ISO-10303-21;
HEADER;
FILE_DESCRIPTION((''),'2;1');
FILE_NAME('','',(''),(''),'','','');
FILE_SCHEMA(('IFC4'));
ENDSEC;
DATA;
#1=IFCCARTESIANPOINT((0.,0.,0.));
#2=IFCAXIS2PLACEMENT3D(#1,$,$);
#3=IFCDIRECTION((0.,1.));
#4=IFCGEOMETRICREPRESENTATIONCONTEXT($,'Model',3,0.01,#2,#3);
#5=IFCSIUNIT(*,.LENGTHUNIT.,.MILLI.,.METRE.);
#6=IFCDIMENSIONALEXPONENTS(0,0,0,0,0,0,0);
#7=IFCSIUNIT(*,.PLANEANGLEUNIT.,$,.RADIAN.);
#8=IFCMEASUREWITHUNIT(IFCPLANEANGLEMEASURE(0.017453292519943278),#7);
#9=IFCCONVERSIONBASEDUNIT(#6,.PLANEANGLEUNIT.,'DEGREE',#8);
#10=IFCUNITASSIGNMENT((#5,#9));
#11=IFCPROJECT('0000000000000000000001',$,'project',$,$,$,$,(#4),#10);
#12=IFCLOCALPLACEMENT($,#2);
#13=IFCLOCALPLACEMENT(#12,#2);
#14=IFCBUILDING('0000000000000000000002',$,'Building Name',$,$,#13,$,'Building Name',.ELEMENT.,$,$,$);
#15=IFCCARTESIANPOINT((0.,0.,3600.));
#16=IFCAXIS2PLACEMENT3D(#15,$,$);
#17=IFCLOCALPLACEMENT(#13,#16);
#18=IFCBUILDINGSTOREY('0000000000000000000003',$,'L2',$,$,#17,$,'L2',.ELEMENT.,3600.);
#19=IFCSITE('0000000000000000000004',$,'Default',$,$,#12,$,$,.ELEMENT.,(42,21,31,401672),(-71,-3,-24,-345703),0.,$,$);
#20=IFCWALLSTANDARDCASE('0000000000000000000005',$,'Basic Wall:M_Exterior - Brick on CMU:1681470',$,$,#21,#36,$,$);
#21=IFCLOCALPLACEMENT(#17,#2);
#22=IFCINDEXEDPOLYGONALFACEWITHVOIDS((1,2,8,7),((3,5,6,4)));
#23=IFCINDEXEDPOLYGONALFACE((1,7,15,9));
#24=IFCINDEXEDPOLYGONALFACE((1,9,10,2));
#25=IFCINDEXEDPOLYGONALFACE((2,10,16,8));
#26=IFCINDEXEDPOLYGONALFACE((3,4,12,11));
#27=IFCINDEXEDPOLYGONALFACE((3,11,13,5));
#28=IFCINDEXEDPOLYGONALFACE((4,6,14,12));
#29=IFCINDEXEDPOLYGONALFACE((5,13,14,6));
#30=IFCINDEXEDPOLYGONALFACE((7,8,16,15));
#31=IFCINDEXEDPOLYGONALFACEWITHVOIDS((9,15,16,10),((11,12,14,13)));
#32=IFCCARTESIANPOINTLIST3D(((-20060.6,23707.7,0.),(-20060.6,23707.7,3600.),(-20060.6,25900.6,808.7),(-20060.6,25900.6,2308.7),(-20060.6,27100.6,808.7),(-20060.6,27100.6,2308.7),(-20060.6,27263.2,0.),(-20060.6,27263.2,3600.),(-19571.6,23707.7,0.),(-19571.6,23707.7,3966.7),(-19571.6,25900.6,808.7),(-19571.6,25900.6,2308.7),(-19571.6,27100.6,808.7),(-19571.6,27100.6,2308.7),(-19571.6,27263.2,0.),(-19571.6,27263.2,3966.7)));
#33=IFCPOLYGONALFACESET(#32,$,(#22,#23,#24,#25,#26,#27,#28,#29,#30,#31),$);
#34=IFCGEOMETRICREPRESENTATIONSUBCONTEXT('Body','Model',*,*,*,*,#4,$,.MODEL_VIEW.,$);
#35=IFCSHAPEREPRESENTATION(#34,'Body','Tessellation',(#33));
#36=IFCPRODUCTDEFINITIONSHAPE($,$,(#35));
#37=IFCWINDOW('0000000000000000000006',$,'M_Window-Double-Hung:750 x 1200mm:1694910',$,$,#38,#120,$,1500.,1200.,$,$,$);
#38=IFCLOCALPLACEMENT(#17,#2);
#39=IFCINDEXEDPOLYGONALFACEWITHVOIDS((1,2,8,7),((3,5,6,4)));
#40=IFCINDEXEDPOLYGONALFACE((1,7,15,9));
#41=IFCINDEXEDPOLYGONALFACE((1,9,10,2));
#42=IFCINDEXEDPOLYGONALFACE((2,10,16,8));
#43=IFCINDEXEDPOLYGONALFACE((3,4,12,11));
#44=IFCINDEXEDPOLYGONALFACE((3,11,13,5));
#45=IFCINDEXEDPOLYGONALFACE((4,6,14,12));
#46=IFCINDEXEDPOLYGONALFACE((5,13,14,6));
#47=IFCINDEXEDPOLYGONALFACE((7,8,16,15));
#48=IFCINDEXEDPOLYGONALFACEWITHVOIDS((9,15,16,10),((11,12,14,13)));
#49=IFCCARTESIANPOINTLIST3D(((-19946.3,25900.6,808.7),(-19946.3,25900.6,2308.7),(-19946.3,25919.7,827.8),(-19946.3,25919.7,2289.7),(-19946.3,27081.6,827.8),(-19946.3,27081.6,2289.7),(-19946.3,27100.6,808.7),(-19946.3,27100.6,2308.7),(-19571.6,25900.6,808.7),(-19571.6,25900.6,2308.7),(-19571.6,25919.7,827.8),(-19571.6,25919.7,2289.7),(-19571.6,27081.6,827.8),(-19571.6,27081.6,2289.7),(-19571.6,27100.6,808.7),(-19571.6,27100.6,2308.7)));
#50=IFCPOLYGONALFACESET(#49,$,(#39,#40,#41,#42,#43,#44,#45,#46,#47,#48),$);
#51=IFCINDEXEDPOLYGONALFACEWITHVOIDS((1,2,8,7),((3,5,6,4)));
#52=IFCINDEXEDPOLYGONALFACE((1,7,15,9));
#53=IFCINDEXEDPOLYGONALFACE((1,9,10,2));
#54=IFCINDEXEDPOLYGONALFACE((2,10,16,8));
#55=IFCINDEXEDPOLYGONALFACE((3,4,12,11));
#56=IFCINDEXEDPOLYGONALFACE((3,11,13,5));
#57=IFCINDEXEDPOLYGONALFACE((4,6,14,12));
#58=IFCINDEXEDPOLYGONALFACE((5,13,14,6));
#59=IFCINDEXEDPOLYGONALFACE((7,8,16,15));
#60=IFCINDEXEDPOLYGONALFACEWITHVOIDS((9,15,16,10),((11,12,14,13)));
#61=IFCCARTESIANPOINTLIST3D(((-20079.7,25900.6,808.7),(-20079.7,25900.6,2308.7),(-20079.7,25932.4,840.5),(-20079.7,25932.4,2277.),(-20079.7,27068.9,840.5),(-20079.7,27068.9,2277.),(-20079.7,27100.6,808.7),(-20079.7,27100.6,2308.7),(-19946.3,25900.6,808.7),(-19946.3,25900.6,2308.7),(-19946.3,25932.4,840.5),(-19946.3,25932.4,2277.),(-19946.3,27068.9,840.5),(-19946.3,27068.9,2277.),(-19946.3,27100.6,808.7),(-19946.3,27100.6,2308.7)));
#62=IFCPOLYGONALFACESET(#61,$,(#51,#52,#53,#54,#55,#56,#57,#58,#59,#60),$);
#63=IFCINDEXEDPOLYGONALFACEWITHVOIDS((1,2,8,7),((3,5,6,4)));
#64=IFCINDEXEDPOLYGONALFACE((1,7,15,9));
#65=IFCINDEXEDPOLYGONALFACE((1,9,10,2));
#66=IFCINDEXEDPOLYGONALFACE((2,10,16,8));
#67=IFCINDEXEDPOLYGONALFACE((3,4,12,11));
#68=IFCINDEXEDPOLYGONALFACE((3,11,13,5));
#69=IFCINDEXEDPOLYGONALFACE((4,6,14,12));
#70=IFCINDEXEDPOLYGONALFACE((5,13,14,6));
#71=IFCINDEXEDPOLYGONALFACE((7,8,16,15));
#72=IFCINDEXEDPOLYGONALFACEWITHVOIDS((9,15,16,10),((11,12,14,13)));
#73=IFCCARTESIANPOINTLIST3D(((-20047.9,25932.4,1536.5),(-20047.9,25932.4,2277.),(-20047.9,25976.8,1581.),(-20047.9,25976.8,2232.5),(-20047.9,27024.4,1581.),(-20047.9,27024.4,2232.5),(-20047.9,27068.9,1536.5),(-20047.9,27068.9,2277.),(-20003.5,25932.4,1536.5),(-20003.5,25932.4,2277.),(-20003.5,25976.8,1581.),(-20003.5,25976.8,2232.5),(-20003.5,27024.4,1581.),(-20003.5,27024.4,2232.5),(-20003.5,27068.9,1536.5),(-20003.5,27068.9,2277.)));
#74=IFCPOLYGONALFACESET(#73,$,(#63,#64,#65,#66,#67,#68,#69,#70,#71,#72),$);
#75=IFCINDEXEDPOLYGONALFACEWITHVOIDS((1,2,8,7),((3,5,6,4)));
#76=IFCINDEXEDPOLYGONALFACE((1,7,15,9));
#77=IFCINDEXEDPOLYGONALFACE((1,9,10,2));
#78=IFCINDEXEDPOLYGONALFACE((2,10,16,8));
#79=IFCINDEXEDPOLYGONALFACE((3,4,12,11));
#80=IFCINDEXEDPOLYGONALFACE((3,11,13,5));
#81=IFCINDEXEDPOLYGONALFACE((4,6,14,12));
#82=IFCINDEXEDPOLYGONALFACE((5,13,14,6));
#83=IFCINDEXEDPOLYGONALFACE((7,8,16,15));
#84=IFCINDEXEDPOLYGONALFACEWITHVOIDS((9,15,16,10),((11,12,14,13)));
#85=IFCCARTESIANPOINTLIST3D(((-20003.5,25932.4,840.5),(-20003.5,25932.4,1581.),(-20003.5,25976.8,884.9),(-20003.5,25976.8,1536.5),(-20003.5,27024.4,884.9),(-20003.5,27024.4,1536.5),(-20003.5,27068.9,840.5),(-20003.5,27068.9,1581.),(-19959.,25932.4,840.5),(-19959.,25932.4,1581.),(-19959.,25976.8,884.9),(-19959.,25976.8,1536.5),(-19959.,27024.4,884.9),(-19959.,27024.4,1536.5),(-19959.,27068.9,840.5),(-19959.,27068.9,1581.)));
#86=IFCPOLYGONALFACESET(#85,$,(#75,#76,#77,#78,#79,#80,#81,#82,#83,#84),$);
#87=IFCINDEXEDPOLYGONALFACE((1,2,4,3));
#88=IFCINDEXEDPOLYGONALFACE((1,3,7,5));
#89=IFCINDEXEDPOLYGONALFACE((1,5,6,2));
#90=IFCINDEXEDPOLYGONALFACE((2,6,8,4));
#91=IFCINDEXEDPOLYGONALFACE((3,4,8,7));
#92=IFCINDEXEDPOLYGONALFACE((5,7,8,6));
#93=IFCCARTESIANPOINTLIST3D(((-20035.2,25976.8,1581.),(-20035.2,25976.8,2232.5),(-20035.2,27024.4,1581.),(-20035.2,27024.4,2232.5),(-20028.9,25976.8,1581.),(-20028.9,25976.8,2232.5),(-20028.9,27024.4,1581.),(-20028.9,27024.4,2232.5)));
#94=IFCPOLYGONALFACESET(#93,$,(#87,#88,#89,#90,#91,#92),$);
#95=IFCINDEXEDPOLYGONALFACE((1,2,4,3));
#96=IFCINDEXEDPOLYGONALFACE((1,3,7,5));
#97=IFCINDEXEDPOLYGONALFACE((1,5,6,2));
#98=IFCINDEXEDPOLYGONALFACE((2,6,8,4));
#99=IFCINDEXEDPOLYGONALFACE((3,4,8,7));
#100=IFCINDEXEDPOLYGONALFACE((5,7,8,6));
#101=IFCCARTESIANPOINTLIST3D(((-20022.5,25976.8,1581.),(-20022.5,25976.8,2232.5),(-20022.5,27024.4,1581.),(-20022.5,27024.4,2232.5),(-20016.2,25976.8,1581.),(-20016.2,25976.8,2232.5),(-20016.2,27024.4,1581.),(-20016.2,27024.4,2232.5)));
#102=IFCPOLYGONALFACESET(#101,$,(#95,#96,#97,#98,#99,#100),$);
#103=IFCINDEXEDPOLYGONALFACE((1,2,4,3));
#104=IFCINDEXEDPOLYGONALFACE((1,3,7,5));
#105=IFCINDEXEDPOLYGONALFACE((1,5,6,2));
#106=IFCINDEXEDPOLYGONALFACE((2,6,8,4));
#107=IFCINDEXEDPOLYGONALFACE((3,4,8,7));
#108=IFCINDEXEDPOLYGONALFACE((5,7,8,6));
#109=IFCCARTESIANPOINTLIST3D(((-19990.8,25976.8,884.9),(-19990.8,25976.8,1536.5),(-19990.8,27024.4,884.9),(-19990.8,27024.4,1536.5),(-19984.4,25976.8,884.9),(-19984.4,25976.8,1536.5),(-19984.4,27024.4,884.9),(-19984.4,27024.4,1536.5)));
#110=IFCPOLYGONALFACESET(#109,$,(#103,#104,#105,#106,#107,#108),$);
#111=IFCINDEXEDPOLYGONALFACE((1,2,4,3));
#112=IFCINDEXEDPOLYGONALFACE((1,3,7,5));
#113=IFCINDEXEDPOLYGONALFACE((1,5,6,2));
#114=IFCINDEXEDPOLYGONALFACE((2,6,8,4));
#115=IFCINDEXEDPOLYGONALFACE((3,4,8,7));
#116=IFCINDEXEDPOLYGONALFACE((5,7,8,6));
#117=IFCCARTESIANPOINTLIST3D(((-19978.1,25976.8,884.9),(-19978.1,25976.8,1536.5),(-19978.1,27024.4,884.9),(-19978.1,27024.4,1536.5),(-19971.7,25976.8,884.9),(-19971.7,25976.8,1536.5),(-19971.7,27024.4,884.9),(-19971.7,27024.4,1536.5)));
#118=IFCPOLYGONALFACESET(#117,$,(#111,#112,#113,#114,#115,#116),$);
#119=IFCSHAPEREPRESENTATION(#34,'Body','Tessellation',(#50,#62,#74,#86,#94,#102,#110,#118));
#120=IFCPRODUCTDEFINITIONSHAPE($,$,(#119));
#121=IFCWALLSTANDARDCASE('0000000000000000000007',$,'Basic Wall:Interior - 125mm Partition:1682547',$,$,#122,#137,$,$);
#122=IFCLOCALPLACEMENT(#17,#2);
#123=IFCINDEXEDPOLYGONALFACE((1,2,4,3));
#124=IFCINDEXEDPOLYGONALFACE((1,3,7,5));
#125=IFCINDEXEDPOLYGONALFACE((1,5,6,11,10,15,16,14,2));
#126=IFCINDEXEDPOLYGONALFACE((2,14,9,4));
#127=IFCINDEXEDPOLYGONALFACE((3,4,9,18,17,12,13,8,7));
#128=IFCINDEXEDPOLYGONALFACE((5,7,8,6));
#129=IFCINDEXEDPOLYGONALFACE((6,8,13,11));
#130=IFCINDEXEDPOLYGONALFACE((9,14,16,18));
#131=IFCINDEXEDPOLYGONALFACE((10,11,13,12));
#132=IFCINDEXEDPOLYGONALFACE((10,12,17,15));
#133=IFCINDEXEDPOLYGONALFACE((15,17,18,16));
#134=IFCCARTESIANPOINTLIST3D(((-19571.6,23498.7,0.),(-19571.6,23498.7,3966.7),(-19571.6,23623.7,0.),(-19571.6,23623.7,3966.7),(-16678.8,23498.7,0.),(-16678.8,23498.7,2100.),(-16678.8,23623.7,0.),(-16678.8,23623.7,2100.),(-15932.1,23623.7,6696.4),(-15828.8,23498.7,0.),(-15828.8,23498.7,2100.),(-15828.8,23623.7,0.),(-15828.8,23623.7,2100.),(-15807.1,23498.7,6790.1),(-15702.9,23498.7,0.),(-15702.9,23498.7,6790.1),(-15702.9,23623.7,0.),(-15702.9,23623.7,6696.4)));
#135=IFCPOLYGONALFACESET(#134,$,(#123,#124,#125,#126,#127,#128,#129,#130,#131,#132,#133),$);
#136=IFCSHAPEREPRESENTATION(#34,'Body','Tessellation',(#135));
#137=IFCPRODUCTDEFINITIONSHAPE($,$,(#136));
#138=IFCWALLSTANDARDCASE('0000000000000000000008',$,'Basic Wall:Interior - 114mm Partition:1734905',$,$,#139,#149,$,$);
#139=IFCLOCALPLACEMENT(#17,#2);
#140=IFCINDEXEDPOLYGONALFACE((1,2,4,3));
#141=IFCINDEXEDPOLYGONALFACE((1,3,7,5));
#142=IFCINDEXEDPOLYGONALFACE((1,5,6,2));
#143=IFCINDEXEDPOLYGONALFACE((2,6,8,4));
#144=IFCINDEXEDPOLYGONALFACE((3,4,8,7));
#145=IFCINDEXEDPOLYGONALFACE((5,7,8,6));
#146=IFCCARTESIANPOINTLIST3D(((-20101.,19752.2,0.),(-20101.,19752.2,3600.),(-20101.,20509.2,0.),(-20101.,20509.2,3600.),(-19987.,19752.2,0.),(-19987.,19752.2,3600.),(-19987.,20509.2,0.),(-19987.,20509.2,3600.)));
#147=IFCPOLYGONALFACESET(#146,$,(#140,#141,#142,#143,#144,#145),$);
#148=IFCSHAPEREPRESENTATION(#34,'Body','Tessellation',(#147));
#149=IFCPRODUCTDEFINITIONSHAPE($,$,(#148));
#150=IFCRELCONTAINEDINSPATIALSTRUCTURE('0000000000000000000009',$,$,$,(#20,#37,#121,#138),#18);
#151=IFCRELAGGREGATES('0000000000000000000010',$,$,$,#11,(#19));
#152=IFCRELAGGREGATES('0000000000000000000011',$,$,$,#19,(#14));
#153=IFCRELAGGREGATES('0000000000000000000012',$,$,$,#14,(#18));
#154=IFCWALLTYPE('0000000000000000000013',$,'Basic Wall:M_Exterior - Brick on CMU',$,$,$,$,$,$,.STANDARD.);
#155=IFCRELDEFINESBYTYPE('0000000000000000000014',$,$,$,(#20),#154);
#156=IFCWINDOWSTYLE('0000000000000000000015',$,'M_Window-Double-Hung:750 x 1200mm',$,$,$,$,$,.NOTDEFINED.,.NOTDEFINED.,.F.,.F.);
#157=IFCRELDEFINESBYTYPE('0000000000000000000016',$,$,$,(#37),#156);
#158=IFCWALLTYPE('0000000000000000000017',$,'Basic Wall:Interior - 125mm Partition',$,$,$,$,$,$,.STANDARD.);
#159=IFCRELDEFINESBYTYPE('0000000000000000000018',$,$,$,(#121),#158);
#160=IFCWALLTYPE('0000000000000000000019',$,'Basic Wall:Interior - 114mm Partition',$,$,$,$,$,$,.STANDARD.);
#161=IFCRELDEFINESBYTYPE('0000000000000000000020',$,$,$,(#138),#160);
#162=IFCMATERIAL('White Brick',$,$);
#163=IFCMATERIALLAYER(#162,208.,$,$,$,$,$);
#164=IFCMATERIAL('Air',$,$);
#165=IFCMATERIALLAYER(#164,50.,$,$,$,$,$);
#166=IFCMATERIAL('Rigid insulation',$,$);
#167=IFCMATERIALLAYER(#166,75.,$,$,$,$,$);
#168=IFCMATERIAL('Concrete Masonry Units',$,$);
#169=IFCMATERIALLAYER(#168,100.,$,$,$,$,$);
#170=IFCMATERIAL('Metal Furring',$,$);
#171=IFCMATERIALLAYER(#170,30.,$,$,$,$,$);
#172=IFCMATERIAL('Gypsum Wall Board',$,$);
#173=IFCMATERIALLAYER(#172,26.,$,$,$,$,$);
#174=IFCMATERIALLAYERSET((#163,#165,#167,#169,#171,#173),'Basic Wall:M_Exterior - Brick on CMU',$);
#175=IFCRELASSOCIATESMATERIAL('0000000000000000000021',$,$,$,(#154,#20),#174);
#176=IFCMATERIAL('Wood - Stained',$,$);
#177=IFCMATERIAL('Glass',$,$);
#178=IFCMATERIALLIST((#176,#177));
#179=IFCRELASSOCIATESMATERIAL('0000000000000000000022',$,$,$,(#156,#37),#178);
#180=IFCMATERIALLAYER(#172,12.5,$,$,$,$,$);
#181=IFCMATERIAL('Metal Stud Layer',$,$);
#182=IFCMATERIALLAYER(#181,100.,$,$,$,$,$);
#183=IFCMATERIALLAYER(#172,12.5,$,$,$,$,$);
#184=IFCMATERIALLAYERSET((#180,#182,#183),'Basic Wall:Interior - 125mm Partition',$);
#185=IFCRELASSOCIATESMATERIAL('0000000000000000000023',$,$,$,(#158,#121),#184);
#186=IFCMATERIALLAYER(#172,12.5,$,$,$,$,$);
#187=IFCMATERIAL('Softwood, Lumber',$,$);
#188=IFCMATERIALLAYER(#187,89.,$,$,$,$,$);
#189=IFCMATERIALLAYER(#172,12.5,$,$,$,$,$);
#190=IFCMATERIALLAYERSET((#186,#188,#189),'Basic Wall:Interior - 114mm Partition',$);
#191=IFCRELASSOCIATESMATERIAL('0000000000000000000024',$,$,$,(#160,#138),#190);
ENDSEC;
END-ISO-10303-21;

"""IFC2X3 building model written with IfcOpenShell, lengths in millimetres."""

from ifc_helpers import new_model, entity, si_unit, converted_unit, direction, frame, frame_2d, origin, place, context, subcontext, project, spatial, polyline, rectangle, outline, extrude, clip, bounded_halfspace, source, transform, mapped, material, material_list, layer, layer_set, layer_usage, type_object, type_shapes, element, fill, save


model = new_model("IFC2X3")

# Units and contexts
model_context = context("Model", 3, precision=0.01, world=origin(), true_north=direction((0.0, 1.0)))
body_context = subcontext(model_context, "Body", "Model", "MODEL_VIEW")
ifc_project = project(units=[si_unit("LENGTHUNIT", "METRE", prefix="MILLI"), converted_unit("PLANEANGLEUNIT", "DEGREE", entity("IfcPlaneAngleMeasure", 0.017453292519943278), si_unit("PLANEANGLEUNIT", "RADIAN"), dimensions=[0, 0, 0, 0, 0, 0, 0])], contexts=[model_context])

# Site, building, storey
site_placement = place(None, origin())
site = spatial("IfcSite", under=ifc_project, at=site_placement, Name="Default", CompositionType="ELEMENT", RefLatitude=(42, 21, 31, 401672), RefLongitude=(-71, -3, -24, -345703), RefElevation=0.0)
building_placement = place(site_placement, origin())
building = spatial("IfcBuilding", under=site, at=building_placement, Name="Building Name", LongName="Building Name", CompositionType="ELEMENT")
storey_placement = place(building_placement, frame((0.0, 0.0, 3600.0)))
storey = spatial("IfcBuildingStorey", under=building, at=storey_placement, Name="L2", LongName="L2", CompositionType="ELEMENT", Elevation=3600.0)

# Shared definitions
ifc_material_1 = material(Name="White Brick")
ifc_layer_1 = layer(ifc_material_1, 208.0)
ifc_material_2 = material(Name="Air")
ifc_layer_2 = layer(ifc_material_2, 50.0)
ifc_material_3 = material(Name="Rigid insulation")
ifc_layer_3 = layer(ifc_material_3, 75.0)
ifc_material_4 = material(Name="Concrete Masonry Units")
ifc_layer_4 = layer(ifc_material_4, 100.0)
ifc_material_5 = material(Name="Metal Furring")
ifc_layer_5 = layer(ifc_material_5, 30.0)
ifc_material_6 = material(Name="Gypsum Wall Board")
ifc_layer_6 = layer(ifc_material_6, 26.0)
ifc_layer_set_1 = layer_set([ifc_layer_1, ifc_layer_2, ifc_layer_3, ifc_layer_4, ifc_layer_5, ifc_layer_6], Name="Basic Wall:M_Exterior - Brick on CMU")
wall_type_1 = type_object("IfcWallType", Name="Basic Wall:M_Exterior - Brick on CMU", PredefinedType="STANDARD", material=ifc_layer_set_1)
ifc_material_7 = material(Name="Wood - Stained")
ifc_material_8 = material(Name="Glass")
ifc_material_list_1 = material_list([ifc_material_7, ifc_material_8])
window_style = type_object("IfcWindowStyle", Name="M_Window-Double-Hung:750 x 1200mm", ConstructionType="NOTDEFINED", OperationType="NOTDEFINED", ParameterTakesPrecedence=False, Sizeable=False, material=ifc_material_list_1)
shared_shape_1 = source(origin(), body_context, "Body", "SweptSolid", [
    extrude(outline(polyline([(-750.0, -600.0), (750.0, -600.0), (750.0, 600.0), (-750.0, 600.0), (-750.0, -600.0)]), holes=[polyline([(-730.9, -580.9), (-730.9, 580.9), (730.9, 580.9), (730.9, -580.9), (-730.9, -580.9)])]), frame((600.0, 0.0, 750.0), z_axis=(0.0, 1.0, 0.0), x_axis=(0.0, 0.0, -1.0)), (0.0, 0.0, 1.0), 374.7),
    extrude(outline(polyline([(-600.0, -750.0), (600.0, -750.0), (600.0, 750.0), (-600.0, 750.0), (-600.0, -750.0)]), holes=[polyline([(568.2, -718.2), (-568.2, -718.2), (-568.2, 718.2), (568.2, 718.2), (568.2, -718.2)])]), frame((600.0, 374.7, 750.0), z_axis=(0.0, 1.0, 0.0), x_axis=(1.0, 0.0, 0.0)), (0.0, 0.0, 1.0), 133.3),
    extrude(outline(polyline([(-568.2, -370.2), (568.2, -370.2), (568.2, 370.2), (-568.2, 370.2), (-568.2, -370.2)]), holes=[polyline([(523.8, -325.8), (-523.8, -325.8), (-523.8, 325.8), (523.8, 325.8), (523.8, -325.8)])]), frame((600.0, 431.8, 1098.0), z_axis=(0.0, 1.0, 0.0), x_axis=(1.0, 0.0, 0.0)), (0.0, 0.0, 1.0), 44.4),
    extrude(outline(polyline([(-568.2, -370.2), (568.2, -370.2), (568.2, 370.2), (-568.2, 370.2), (-568.2, -370.2)]), holes=[polyline([(523.8, -325.8), (-523.8, -325.8), (-523.8, 325.8), (523.8, 325.8), (523.8, -325.8)])]), frame((600.0, 387.4, 402.0), z_axis=(0.0, 1.0, 0.0), x_axis=(1.0, 0.0, 0.0)), (0.0, 0.0, 1.0), 44.5),
    extrude(rectangle(XDim=1047.6, YDim=6.4, at=frame_2d((0.0, 0.0), x_axis=(1.0, 0.0))), frame((600.0, 460.4, 772.2), z_axis=(0.0, 0.0, 1.0), x_axis=(-1.0, 0.0, 0.0)), (0.0, 0.0, 1.0), 651.6),
    extrude(rectangle(XDim=6.4, YDim=1047.6, at=frame_2d((0.0, 0.0), x_axis=(1.0, 0.0))), frame((600.0, 447.7, 772.2), z_axis=(0.0, 0.0, 1.0), x_axis=(0.0, -1.0, 0.0)), (0.0, 0.0, 1.0), 651.6),
    extrude(rectangle(XDim=1047.6, YDim=6.4, at=frame_2d((0.0, 0.0), x_axis=(1.0, 0.0))), frame((600.0, 416.0, 76.2), z_axis=(0.0, 0.0, 1.0), x_axis=(-1.0, 0.0, 0.0)), (0.0, 0.0, 1.0), 651.6),
    extrude(rectangle(XDim=6.4, YDim=1047.6, at=frame_2d((0.0, 0.0), x_axis=(1.0, 0.0))), frame((600.0, 403.3, 76.2), z_axis=(0.0, 0.0, 1.0), x_axis=(0.0, -1.0, 0.0)), (0.0, 0.0, 1.0), 651.6),
])
type_shapes(window_style, [shared_shape_1])

# Wall, opening, window
ifc_layer_usage_1 = layer_usage(ifc_layer_set_1, "AXIS2", "NEGATIVE", 244.5)
wall_1_placement = place(storey_placement, frame((-19816.1, 23707.7, 0.0), z_axis=(0.0, 0.0, 1.0), x_axis=(0.0, 1.0, 0.0)))
wall_1 = element("IfcWallStandardCase", 1, at=wall_1_placement, inside=storey, type_object=wall_type_1, material=ifc_layer_usage_1, Name="Basic Wall:M_Exterior - Brick on CMU:1681470", context=body_context, shape_type="Clipping", body=[
    clip(extrude(rectangle(XDim=3555.5, YDim=489.0, at=frame_2d((1777.7, 0.0), x_axis=(-1.0, 0.0))), origin(), (0.0, 0.0, 1.0), 3966.7), bounded_halfspace(frame((0.0, -244.5, 3966.7), z_axis=(0.0, 0.6, 0.8), x_axis=(-1.0, 0.0, 0.0)), False, frame((0.0, -244.5, 3966.7)), polyline([(0.0, 0.0), (3555.5, 0.0), (3555.5, 489.0), (0.0, 489.0), (0.0, 0.0)]))),
])
opening_1_placement = place(wall_1_placement, frame((2193.0, -244.5, 808.7)))
opening_1 = element("IfcOpeningElement", 2, at=opening_1_placement, cuts=wall_1, ObjectType="Opening", context=body_context, shape_type="SweptSolid", body=[
    extrude(rectangle(XDim=1500.0, YDim=1200.0, at=frame_2d((750.0, 600.0), x_axis=(-1.0, 0.0))), frame((0.0, 0.0, 0.0), z_axis=(0.0, 1.0, 0.0), x_axis=(0.0, 0.0, 1.0)), (0.0, 0.0, 1.0), 489.0),
])
window_1_placement = place(opening_1_placement, origin())
window_1 = element("IfcWindow", 3, at=window_1_placement, inside=storey, type_object=window_style, material=ifc_material_list_1, Name="M_Window-Double-Hung:750 x 1200mm:1694910", OverallHeight=1500.0, OverallWidth=1200.0, context=body_context, shape_type="MappedRepresentation", body=[
    mapped(shared_shape_1, transform((0.0, 0.0, 0.0), scale=1.0)),
])
fill(opening_1, window_1)

# Wall, opening
ifc_layer_7 = layer(ifc_material_6, 12.5)
ifc_material_9 = material(Name="Metal Stud Layer")
ifc_layer_8 = layer(ifc_material_9, 100.0)
ifc_layer_9 = layer(ifc_material_6, 12.5)
ifc_layer_set_2 = layer_set([ifc_layer_7, ifc_layer_8, ifc_layer_9], Name="Basic Wall:Interior - 125mm Partition")
ifc_layer_usage_2 = layer_usage(ifc_layer_set_2, "AXIS2", "NEGATIVE", 62.5)
wall_type_2 = type_object("IfcWallType", Name="Basic Wall:Interior - 125mm Partition", PredefinedType="STANDARD", material=ifc_layer_set_2)
wall_2_placement = place(storey_placement, frame((-19571.6, 23561.2, 0.0)))
wall_2 = element("IfcWallStandardCase", 4, at=wall_2_placement, inside=storey, type_object=wall_type_2, material=ifc_layer_usage_2, Name="Basic Wall:Interior - 125mm Partition:1682547", context=body_context, shape_type="Clipping", body=[
    clip(clip(extrude(rectangle(XDim=125.0, YDim=3868.8, at=frame_2d((1934.4, 0.0), x_axis=(0.0, 1.0))), origin(), (0.0, 0.0, 1.0), 6790.1), bounded_halfspace(frame((3764.5, -62.5, 6790.1), z_axis=(0.0, 0.6, 0.8), x_axis=(-1.0, 0.0, 0.0)), False, frame((3764.5, -62.5, 6790.1)), polyline([(0.0, 0.0), (104.3, 0.0), (104.3, 125.0), (-125.0, 125.0), (0.0, 0.0)]))), bounded_halfspace(frame((0.0, -62.5, 3966.7), z_axis=(-0.6, 0.0, 0.8), x_axis=(0.0, -1.0, 0.0)), False, frame((0.0, -62.5, 3966.7)), polyline([(0.0, 0.0), (2642.0, 0.0), (2767.0, 0.0), (3764.5, 0.0), (3639.5, 125.0), (0.0, 125.0), (0.0, 0.0)]))),
])
opening_2_placement = place(wall_2_placement, frame((2892.9, -62.5, 0.0)))
element("IfcOpeningElement", 5, at=opening_2_placement, cuts=wall_2, ObjectType="Opening", context=body_context, shape_type="SweptSolid", body=[
    extrude(rectangle(XDim=2100.0, YDim=850.0, at=frame_2d((1050.0, 425.0), x_axis=(1.0, 0.0))), frame((0.0, 0.0, 0.0), z_axis=(0.0, 1.0, 0.0), x_axis=(0.0, 0.0, 1.0)), (0.0, 0.0, 1.0), 125.0),
])

# Wall
ifc_layer_10 = layer(ifc_material_6, 12.5)
ifc_material_10 = material(Name="Softwood, Lumber")
ifc_layer_11 = layer(ifc_material_10, 89.0)
ifc_layer_12 = layer(ifc_material_6, 12.5)
ifc_layer_set_3 = layer_set([ifc_layer_10, ifc_layer_11, ifc_layer_12], Name="Basic Wall:Interior - 114mm Partition")
ifc_layer_usage_3 = layer_usage(ifc_layer_set_3, "AXIS2", "NEGATIVE", 57.0)
wall_type_3 = type_object("IfcWallType", Name="Basic Wall:Interior - 114mm Partition", PredefinedType="STANDARD", material=ifc_layer_set_3)
wall_3_placement = place(storey_placement, frame((-20044.0, 19752.2, 0.0), z_axis=(0.0, 0.0, 1.0), x_axis=(0.0, 1.0, 0.0)))
element("IfcWallStandardCase", 6, at=wall_3_placement, inside=storey, type_object=wall_type_3, material=ifc_layer_usage_3, Name="Basic Wall:Interior - 114mm Partition:1734905", context=body_context, shape_type="SweptSolid", body=[
    extrude(rectangle(XDim=757.0, YDim=114.0, at=frame_2d((378.5, 0.0), x_axis=(-1.0, 0.0))), origin(), (0.0, 0.0, 1.0), 3600.0),
])

save(model, "model.ifc")
